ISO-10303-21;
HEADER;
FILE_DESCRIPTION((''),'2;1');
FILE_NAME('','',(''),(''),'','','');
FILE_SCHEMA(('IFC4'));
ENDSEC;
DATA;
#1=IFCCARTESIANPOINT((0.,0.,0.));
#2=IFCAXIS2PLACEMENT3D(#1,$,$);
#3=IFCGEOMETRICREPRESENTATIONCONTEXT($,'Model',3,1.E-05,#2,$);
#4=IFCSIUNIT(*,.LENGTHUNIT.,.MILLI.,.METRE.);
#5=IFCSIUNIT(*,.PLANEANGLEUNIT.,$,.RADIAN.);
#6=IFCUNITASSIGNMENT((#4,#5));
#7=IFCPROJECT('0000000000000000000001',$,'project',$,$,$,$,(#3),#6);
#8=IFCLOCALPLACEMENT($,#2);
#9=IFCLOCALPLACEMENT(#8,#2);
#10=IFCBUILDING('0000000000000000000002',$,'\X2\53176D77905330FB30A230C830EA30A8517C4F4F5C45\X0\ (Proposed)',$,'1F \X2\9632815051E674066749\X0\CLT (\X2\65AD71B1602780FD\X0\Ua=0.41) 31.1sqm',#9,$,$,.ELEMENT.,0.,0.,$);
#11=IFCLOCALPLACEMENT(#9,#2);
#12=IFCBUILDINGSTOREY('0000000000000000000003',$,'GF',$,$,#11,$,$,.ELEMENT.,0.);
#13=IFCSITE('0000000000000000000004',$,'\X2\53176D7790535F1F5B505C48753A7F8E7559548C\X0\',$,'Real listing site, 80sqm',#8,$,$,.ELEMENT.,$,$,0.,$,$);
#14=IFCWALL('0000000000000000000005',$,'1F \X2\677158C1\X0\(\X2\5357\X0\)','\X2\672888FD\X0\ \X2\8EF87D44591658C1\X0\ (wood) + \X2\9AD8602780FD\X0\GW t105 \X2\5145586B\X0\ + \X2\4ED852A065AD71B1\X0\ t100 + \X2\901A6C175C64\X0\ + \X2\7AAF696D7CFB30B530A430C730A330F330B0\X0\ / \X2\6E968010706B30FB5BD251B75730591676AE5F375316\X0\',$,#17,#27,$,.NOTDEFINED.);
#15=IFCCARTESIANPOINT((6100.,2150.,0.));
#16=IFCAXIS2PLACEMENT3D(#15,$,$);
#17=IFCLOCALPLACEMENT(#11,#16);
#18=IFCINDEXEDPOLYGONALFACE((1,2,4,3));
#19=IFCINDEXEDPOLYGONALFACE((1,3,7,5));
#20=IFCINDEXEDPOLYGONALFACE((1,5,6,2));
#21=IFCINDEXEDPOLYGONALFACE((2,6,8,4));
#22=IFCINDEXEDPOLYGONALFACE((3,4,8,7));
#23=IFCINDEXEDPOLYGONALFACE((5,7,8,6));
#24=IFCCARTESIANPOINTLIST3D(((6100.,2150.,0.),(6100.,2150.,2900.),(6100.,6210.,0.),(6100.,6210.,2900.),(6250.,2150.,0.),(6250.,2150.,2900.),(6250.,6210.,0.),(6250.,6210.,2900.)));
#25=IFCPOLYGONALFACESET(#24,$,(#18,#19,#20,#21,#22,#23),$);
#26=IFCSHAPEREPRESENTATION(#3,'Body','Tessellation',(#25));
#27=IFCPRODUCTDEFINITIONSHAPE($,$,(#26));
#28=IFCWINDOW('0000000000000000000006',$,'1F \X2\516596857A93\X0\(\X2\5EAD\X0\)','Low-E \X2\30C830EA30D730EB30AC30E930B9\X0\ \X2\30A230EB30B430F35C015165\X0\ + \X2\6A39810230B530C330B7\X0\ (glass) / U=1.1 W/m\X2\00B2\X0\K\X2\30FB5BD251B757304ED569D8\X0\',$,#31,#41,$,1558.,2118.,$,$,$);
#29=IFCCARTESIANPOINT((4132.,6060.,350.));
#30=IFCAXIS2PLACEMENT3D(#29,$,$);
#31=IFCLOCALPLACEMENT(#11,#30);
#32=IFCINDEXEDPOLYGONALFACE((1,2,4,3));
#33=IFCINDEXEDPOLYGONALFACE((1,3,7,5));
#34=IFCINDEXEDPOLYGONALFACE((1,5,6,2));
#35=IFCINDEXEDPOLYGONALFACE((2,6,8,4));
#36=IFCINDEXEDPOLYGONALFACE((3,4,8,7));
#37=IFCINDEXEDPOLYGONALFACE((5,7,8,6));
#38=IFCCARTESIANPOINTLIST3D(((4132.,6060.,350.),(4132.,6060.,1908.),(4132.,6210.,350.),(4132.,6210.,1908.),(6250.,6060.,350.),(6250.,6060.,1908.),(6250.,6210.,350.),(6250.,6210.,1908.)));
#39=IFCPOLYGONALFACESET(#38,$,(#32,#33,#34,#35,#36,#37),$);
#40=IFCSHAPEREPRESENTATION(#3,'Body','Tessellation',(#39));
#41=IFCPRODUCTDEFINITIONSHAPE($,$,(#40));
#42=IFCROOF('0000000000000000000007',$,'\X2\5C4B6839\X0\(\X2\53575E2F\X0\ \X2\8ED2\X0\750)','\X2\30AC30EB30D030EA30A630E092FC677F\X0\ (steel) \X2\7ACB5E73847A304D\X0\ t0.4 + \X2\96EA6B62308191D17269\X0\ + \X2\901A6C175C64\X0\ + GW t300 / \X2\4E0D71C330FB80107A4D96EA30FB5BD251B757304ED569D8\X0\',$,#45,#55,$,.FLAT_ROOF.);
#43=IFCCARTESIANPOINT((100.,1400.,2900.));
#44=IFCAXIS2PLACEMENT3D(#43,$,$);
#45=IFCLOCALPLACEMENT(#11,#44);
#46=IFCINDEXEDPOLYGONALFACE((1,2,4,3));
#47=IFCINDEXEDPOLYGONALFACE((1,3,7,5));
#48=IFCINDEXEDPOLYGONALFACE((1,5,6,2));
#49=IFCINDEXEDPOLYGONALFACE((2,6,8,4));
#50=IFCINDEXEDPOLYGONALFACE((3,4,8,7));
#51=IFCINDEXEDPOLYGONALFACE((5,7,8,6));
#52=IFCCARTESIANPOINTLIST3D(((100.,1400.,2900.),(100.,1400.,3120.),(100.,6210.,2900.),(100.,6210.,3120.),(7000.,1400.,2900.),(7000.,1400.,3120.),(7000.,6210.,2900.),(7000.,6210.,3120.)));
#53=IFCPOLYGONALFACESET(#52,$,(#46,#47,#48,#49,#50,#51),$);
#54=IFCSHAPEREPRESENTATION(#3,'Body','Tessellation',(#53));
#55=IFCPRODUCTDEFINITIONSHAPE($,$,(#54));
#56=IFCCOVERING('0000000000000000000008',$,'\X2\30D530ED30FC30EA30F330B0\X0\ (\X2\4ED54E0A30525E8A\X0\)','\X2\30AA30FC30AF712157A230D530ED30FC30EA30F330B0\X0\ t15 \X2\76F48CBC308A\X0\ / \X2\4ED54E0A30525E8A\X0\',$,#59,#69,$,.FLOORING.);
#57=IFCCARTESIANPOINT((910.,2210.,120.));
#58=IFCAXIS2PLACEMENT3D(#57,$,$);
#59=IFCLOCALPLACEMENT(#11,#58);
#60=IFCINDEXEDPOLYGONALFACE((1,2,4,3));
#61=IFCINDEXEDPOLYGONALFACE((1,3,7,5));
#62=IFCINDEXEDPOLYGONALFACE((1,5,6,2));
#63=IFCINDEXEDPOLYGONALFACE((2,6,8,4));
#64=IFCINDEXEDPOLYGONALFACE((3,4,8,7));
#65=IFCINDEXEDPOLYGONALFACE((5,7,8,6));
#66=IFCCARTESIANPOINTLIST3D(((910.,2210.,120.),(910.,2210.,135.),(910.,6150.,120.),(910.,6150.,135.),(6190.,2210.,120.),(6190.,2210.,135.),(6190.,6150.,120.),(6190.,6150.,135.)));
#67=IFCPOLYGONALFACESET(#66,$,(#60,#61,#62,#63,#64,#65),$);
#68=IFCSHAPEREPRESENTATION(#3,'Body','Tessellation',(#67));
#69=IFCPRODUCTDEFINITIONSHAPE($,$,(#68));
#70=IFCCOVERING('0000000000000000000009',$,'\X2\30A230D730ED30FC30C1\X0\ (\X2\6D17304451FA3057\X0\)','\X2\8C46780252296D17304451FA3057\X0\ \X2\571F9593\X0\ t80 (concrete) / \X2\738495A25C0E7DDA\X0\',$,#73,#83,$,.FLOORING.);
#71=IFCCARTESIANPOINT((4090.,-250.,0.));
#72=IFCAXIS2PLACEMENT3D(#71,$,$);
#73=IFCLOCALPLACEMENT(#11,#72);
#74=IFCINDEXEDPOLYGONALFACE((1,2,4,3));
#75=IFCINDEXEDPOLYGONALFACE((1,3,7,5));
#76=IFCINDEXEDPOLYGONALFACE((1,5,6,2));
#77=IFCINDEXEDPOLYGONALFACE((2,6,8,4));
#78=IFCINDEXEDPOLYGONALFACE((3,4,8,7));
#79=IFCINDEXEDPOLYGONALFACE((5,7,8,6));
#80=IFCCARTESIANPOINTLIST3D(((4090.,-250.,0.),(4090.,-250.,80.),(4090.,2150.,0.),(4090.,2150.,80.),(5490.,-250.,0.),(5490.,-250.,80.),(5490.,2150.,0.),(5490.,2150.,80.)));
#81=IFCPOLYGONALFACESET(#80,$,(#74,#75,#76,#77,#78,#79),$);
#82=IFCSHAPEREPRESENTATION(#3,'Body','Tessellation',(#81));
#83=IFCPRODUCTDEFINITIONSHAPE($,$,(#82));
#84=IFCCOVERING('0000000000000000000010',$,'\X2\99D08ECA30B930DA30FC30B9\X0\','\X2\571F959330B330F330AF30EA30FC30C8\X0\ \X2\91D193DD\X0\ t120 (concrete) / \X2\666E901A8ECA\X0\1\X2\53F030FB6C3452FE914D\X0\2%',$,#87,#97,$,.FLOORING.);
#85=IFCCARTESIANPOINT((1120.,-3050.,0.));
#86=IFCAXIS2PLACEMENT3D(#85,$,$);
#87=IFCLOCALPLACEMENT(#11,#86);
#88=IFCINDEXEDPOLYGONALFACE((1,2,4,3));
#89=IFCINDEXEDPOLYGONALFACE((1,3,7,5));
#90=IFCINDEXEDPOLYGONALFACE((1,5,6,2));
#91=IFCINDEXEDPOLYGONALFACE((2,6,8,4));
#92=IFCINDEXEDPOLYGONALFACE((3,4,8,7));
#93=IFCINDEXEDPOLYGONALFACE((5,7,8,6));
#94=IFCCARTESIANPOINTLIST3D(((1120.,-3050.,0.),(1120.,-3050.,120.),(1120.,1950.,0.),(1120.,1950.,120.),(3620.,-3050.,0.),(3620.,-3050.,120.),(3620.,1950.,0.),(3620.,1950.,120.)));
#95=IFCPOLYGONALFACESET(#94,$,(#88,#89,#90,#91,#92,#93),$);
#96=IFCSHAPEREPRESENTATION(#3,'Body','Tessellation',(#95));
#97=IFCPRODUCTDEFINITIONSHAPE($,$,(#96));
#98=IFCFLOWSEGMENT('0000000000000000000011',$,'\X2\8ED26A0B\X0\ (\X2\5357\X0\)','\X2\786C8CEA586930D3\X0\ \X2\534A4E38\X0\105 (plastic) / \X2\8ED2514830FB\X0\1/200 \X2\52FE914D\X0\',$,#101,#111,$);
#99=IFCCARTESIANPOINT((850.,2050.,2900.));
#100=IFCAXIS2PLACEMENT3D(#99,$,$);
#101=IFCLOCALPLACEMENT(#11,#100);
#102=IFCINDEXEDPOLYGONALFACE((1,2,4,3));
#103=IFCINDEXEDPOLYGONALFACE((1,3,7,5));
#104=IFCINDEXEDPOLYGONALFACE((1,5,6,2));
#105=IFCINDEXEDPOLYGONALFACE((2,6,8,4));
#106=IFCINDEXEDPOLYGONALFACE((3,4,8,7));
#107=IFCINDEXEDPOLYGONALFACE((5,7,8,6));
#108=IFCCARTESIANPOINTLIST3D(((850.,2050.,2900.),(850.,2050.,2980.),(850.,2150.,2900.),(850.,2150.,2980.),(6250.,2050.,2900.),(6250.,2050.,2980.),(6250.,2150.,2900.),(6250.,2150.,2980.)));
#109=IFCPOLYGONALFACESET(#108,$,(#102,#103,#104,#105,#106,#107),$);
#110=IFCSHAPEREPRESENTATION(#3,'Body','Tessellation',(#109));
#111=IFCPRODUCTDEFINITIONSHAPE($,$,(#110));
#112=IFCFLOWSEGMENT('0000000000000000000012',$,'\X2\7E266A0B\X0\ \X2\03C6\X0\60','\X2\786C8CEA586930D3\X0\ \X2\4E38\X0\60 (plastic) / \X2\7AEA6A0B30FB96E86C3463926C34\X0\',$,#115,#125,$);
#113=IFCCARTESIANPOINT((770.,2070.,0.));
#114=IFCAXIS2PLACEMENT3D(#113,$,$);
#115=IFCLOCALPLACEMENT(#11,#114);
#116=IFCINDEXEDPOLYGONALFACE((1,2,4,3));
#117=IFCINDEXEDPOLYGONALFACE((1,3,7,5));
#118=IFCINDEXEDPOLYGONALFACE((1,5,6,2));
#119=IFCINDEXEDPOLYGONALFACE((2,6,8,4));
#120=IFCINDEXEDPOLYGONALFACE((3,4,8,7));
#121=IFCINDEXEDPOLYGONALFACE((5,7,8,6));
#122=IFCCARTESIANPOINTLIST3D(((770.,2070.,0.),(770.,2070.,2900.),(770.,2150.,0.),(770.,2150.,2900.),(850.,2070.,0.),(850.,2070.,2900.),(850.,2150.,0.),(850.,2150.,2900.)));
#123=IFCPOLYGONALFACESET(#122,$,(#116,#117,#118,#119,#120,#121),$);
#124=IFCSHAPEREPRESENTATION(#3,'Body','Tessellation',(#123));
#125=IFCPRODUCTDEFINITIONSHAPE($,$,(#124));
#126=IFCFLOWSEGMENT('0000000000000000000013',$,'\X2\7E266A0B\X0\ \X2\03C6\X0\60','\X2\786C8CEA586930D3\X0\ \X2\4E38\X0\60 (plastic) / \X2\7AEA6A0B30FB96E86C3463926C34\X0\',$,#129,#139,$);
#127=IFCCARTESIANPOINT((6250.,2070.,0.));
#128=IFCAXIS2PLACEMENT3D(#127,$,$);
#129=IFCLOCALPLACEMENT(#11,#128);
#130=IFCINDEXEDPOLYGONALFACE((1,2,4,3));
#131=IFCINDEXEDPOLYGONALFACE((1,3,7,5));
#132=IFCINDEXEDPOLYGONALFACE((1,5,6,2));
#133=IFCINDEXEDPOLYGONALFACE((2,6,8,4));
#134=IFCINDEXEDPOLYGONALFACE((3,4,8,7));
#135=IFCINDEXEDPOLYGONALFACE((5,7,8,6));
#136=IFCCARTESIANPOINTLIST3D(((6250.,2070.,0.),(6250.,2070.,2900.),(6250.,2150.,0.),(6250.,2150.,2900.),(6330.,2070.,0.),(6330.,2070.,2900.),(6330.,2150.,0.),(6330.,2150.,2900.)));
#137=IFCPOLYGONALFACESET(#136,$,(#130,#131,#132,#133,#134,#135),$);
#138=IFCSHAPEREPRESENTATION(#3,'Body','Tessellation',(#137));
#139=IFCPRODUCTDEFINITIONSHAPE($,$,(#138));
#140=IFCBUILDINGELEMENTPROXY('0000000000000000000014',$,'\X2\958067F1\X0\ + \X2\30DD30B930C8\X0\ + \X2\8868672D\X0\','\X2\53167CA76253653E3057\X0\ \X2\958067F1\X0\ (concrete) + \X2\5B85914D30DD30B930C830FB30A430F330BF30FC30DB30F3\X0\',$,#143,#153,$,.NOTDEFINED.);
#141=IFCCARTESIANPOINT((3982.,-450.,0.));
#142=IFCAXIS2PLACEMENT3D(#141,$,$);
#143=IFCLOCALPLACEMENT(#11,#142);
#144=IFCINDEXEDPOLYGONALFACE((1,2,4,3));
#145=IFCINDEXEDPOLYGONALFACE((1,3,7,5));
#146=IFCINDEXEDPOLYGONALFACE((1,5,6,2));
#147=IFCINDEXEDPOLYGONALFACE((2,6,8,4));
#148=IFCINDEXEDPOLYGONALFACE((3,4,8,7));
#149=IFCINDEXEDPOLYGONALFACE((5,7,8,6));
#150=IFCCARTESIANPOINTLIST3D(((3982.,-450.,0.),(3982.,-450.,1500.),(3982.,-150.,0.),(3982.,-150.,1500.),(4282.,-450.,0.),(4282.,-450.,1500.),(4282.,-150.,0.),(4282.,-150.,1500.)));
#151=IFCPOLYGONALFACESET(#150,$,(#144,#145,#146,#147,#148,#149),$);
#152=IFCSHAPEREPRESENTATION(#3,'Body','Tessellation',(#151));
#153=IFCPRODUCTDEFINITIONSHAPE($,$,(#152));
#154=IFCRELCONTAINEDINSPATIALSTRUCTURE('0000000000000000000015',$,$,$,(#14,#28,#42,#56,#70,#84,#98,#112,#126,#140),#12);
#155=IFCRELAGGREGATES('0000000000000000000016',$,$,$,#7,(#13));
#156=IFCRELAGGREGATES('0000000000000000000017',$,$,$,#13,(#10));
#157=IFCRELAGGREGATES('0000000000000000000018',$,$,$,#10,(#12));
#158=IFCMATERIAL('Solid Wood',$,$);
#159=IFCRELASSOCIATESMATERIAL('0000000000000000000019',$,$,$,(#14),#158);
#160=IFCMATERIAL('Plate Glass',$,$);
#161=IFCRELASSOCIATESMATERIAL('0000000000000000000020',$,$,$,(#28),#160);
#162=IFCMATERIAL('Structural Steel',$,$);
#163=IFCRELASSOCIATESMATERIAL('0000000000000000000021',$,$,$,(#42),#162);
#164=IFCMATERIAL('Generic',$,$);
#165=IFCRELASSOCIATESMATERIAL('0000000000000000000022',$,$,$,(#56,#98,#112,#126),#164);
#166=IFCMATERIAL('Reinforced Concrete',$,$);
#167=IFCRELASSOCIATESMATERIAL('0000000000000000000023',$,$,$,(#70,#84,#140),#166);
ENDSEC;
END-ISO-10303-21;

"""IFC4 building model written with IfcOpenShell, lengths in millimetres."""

from ifc_helpers import new_model, si_unit, frame, frame_2d, origin, place, context, project, spatial, rectangle, extrude, material, element, fill, save


model = new_model("IFC4")

# Units and contexts
model_context = context("Model", 3, precision=1e-05, world=origin())
ifc_project = project(units=[si_unit("LENGTHUNIT", "METRE", prefix="MILLI"), si_unit("PLANEANGLEUNIT", "RADIAN")], contexts=[model_context])

# Site, building, storey
site_placement = place(None, origin())
site = spatial("IfcSite", under=ifc_project, at=site_placement, Name="北海道弟子屈町美留和", ObjectType="Real listing site, 80sqm", CompositionType="ELEMENT", RefElevation=0.0)
building_placement = place(site_placement, origin())
building = spatial("IfcBuilding", under=site, at=building_placement, Name="北海道・アトリエ兼住居 (Proposed)", ObjectType="1F 防腐処理杉CLT (断熱性能Ua=0.41) 31.1sqm", CompositionType="ELEMENT", ElevationOfRefHeight=0.0, ElevationOfTerrain=0.0)
storey_placement = place(building_placement, origin())
storey = spatial("IfcBuildingStorey", under=building, at=storey_placement, Name="GF", CompositionType="ELEMENT", Elevation=0.0)

# Shared definitions
ifc_material_1 = material(Name="Solid Wood")

# Shared definitions
ifc_material_2 = material(Name="Reinforced Concrete")

# Shared definitions
ifc_material_3 = material(Name="Plate Glass")

# Wall, opening, window
wall_1_placement = place(storey_placement, frame((6100.0, 2150.0, 0.0)))
wall_1 = element("IfcWall", 1, at=wall_1_placement, inside=storey, material=ifc_material_1, Name="1F 東壁(南)", Description="木製 軸組外壁 (wood) + 高性能GW t105 充填 + 付加断熱 t100 + 通気層 + 窯業系サイディング / 準耐火・寒冷地外皮強化", PredefinedType="NOTDEFINED", context=model_context, shape_type="SweptSolid", body=[
    extrude(rectangle(XDim=150.0, YDim=4060.0, at=frame_2d((75.0, 2030.0))), frame((6100.0, 2150.0, 0.0)), (0.0, 0.0, 1.0), 2900.0),
])
opening_1_placement = place(storey_placement, frame((4132.0, 6060.0, 350.0)))
opening_1 = element("IfcOpeningElement", 2, at=opening_1_placement, cuts=wall_1, PredefinedType="NOTDEFINED", context=model_context, shape_type="SweptSolid", body=[
    extrude(rectangle(XDim=2118.0, YDim=150.0, at=frame_2d((1059.0, 75.0))), frame((4132.0, 6060.0, 350.0)), (0.0, 0.0, 1.0), 1558.0),
])
window_1_placement = place(storey_placement, frame((4132.0, 6060.0, 350.0)))
window_1 = element("IfcWindow", 3, at=window_1_placement, inside=storey, material=ifc_material_3, Name="1F 入隅窓(庭)", Description="Low-E トリプルガラス アルゴン封入 + 樹脂サッシ (glass) / U=1.1 W/m²K・寒冷地仕様", OverallHeight=1558.0, OverallWidth=2118.0, context=model_context, shape_type="SweptSolid", body=[
    extrude(rectangle(XDim=2118.0, YDim=150.0, at=frame_2d((1059.0, 75.0))), frame((4132.0, 6060.0, 350.0)), (0.0, 0.0, 1.0), 1558.0),
])
fill(opening_1, window_1)

# Roof
ifc_material_4 = material(Name="Structural Steel")
roof_placement = place(storey_placement, frame((100.0, 1400.0, 2900.0)))
element("IfcRoof", 4, at=roof_placement, inside=storey, material=ifc_material_4, Name="屋根(南帯 軒750)", Description="ガルバリウム鋼板 (steel) 立平葺き t0.4 + 雪止め金物 + 通気層 + GW t300 / 不燃・耐積雪・寒冷地仕様", PredefinedType="FLAT_ROOF", context=model_context, shape_type="SweptSolid", body=[
    extrude(rectangle(XDim=6900.0, YDim=4810.0, at=frame_2d((3450.0, 2405.0))), frame((100.0, 1400.0, 2900.0)), (0.0, 0.0, 1.0), 220.0),
])

# Coverings
ifc_material_5 = material(Name="Generic")
covering_1_placement = place(storey_placement, frame((910.0, 2210.0, 120.0)))
element("IfcCovering", 5, at=covering_1_placement, inside=storey, material=ifc_material_5, Name="フローリング (仕上げ床)", Description="オーク無垢フローリング t15 直貼り / 仕上げ床", PredefinedType="FLOORING", context=model_context, shape_type="SweptSolid", body=[
    extrude(rectangle(XDim=5280.0, YDim=3940.0, at=frame_2d((2640.0, 1970.0))), frame((910.0, 2210.0, 120.0)), (0.0, 0.0, 1.0), 15.0),
])
covering_2_placement = place(storey_placement, frame((4090.0, -250.0, 0.0)))
element("IfcCovering", 6, at=covering_2_placement, inside=storey, material=ifc_material_2, Name="アプローチ (洗い出し)", Description="豆砂利洗い出し 土間 t80 (concrete) / 玄関導線", PredefinedType="FLOORING", context=model_context, shape_type="SweptSolid", body=[
    extrude(rectangle(XDim=1400.0, YDim=2400.0, at=frame_2d((700.0, 1200.0))), frame((4090.0, -250.0, 0.0)), (0.0, 0.0, 1.0), 80.0),
])
covering_3_placement = place(storey_placement, frame((1120.0, -3050.0, 0.0)))
element("IfcCovering", 7, at=covering_3_placement, inside=storey, material=ifc_material_2, Name="駐車スペース", Description="土間コンクリート 金鏝 t120 (concrete) / 普通車1台・水勾配2%", PredefinedType="FLOORING", context=model_context, shape_type="SweptSolid", body=[
    extrude(rectangle(XDim=2500.0, YDim=5000.0, at=frame_2d((1250.0, 2500.0))), frame((1120.0, -3050.0, 0.0)), (0.0, 0.0, 1.0), 120.0),
])

# Flow segments
flow_segment_1_placement = place(storey_placement, frame((850.0, 2050.0, 2900.0)))
element("IfcFlowSegment", 8, at=flow_segment_1_placement, inside=storey, material=ifc_material_5, Name="軒樋 (南)", Description="硬質塩ビ 半丸105 (plastic) / 軒先・1/200 勾配", context=model_context, shape_type="SweptSolid", body=[
    extrude(rectangle(XDim=5400.0, YDim=100.0, at=frame_2d((2700.0, 50.0))), frame((850.0, 2050.0, 2900.0)), (0.0, 0.0, 1.0), 80.0),
])
flow_segment_2_placement = place(storey_placement, frame((770.0, 2070.0, 0.0)))
element("IfcFlowSegment", 9, at=flow_segment_2_placement, inside=storey, material=ifc_material_5, Name="縦樋 φ60", Description="硬質塩ビ 丸60 (plastic) / 竪樋・雨水排水", context=model_context, shape_type="SweptSolid", body=[
    extrude(rectangle(XDim=80.0, YDim=80.0, at=frame_2d((40.0, 40.0))), frame((770.0, 2070.0, 0.0)), (0.0, 0.0, 1.0), 2900.0),
])
flow_segment_3_placement = place(storey_placement, frame((6250.0, 2070.0, 0.0)))
element("IfcFlowSegment", 10, at=flow_segment_3_placement, inside=storey, material=ifc_material_5, Name="縦樋 φ60", Description="硬質塩ビ 丸60 (plastic) / 竪樋・雨水排水", context=model_context, shape_type="SweptSolid", body=[
    extrude(rectangle(XDim=80.0, YDim=80.0, at=frame_2d((40.0, 40.0))), frame((6250.0, 2070.0, 0.0)), (0.0, 0.0, 1.0), 2900.0),
])

# Building element proxy
proxy_placement = place(storey_placement, frame((3982.0, -450.0, 0.0)))
element("IfcBuildingElementProxy", 11, at=proxy_placement, inside=storey, material=ifc_material_2, Name="門柱 + ポスト + 表札", Description="化粧打放し 門柱 (concrete) + 宅配ポスト・インターホン", PredefinedType="NOTDEFINED", context=model_context, shape_type="SweptSolid", body=[
    extrude(rectangle(XDim=300.0, YDim=300.0, at=frame_2d((150.0, 150.0))), frame((3982.0, -450.0, 0.0)), (0.0, 0.0, 1.0), 1500.0),
])

save(model, "model.ifc")
